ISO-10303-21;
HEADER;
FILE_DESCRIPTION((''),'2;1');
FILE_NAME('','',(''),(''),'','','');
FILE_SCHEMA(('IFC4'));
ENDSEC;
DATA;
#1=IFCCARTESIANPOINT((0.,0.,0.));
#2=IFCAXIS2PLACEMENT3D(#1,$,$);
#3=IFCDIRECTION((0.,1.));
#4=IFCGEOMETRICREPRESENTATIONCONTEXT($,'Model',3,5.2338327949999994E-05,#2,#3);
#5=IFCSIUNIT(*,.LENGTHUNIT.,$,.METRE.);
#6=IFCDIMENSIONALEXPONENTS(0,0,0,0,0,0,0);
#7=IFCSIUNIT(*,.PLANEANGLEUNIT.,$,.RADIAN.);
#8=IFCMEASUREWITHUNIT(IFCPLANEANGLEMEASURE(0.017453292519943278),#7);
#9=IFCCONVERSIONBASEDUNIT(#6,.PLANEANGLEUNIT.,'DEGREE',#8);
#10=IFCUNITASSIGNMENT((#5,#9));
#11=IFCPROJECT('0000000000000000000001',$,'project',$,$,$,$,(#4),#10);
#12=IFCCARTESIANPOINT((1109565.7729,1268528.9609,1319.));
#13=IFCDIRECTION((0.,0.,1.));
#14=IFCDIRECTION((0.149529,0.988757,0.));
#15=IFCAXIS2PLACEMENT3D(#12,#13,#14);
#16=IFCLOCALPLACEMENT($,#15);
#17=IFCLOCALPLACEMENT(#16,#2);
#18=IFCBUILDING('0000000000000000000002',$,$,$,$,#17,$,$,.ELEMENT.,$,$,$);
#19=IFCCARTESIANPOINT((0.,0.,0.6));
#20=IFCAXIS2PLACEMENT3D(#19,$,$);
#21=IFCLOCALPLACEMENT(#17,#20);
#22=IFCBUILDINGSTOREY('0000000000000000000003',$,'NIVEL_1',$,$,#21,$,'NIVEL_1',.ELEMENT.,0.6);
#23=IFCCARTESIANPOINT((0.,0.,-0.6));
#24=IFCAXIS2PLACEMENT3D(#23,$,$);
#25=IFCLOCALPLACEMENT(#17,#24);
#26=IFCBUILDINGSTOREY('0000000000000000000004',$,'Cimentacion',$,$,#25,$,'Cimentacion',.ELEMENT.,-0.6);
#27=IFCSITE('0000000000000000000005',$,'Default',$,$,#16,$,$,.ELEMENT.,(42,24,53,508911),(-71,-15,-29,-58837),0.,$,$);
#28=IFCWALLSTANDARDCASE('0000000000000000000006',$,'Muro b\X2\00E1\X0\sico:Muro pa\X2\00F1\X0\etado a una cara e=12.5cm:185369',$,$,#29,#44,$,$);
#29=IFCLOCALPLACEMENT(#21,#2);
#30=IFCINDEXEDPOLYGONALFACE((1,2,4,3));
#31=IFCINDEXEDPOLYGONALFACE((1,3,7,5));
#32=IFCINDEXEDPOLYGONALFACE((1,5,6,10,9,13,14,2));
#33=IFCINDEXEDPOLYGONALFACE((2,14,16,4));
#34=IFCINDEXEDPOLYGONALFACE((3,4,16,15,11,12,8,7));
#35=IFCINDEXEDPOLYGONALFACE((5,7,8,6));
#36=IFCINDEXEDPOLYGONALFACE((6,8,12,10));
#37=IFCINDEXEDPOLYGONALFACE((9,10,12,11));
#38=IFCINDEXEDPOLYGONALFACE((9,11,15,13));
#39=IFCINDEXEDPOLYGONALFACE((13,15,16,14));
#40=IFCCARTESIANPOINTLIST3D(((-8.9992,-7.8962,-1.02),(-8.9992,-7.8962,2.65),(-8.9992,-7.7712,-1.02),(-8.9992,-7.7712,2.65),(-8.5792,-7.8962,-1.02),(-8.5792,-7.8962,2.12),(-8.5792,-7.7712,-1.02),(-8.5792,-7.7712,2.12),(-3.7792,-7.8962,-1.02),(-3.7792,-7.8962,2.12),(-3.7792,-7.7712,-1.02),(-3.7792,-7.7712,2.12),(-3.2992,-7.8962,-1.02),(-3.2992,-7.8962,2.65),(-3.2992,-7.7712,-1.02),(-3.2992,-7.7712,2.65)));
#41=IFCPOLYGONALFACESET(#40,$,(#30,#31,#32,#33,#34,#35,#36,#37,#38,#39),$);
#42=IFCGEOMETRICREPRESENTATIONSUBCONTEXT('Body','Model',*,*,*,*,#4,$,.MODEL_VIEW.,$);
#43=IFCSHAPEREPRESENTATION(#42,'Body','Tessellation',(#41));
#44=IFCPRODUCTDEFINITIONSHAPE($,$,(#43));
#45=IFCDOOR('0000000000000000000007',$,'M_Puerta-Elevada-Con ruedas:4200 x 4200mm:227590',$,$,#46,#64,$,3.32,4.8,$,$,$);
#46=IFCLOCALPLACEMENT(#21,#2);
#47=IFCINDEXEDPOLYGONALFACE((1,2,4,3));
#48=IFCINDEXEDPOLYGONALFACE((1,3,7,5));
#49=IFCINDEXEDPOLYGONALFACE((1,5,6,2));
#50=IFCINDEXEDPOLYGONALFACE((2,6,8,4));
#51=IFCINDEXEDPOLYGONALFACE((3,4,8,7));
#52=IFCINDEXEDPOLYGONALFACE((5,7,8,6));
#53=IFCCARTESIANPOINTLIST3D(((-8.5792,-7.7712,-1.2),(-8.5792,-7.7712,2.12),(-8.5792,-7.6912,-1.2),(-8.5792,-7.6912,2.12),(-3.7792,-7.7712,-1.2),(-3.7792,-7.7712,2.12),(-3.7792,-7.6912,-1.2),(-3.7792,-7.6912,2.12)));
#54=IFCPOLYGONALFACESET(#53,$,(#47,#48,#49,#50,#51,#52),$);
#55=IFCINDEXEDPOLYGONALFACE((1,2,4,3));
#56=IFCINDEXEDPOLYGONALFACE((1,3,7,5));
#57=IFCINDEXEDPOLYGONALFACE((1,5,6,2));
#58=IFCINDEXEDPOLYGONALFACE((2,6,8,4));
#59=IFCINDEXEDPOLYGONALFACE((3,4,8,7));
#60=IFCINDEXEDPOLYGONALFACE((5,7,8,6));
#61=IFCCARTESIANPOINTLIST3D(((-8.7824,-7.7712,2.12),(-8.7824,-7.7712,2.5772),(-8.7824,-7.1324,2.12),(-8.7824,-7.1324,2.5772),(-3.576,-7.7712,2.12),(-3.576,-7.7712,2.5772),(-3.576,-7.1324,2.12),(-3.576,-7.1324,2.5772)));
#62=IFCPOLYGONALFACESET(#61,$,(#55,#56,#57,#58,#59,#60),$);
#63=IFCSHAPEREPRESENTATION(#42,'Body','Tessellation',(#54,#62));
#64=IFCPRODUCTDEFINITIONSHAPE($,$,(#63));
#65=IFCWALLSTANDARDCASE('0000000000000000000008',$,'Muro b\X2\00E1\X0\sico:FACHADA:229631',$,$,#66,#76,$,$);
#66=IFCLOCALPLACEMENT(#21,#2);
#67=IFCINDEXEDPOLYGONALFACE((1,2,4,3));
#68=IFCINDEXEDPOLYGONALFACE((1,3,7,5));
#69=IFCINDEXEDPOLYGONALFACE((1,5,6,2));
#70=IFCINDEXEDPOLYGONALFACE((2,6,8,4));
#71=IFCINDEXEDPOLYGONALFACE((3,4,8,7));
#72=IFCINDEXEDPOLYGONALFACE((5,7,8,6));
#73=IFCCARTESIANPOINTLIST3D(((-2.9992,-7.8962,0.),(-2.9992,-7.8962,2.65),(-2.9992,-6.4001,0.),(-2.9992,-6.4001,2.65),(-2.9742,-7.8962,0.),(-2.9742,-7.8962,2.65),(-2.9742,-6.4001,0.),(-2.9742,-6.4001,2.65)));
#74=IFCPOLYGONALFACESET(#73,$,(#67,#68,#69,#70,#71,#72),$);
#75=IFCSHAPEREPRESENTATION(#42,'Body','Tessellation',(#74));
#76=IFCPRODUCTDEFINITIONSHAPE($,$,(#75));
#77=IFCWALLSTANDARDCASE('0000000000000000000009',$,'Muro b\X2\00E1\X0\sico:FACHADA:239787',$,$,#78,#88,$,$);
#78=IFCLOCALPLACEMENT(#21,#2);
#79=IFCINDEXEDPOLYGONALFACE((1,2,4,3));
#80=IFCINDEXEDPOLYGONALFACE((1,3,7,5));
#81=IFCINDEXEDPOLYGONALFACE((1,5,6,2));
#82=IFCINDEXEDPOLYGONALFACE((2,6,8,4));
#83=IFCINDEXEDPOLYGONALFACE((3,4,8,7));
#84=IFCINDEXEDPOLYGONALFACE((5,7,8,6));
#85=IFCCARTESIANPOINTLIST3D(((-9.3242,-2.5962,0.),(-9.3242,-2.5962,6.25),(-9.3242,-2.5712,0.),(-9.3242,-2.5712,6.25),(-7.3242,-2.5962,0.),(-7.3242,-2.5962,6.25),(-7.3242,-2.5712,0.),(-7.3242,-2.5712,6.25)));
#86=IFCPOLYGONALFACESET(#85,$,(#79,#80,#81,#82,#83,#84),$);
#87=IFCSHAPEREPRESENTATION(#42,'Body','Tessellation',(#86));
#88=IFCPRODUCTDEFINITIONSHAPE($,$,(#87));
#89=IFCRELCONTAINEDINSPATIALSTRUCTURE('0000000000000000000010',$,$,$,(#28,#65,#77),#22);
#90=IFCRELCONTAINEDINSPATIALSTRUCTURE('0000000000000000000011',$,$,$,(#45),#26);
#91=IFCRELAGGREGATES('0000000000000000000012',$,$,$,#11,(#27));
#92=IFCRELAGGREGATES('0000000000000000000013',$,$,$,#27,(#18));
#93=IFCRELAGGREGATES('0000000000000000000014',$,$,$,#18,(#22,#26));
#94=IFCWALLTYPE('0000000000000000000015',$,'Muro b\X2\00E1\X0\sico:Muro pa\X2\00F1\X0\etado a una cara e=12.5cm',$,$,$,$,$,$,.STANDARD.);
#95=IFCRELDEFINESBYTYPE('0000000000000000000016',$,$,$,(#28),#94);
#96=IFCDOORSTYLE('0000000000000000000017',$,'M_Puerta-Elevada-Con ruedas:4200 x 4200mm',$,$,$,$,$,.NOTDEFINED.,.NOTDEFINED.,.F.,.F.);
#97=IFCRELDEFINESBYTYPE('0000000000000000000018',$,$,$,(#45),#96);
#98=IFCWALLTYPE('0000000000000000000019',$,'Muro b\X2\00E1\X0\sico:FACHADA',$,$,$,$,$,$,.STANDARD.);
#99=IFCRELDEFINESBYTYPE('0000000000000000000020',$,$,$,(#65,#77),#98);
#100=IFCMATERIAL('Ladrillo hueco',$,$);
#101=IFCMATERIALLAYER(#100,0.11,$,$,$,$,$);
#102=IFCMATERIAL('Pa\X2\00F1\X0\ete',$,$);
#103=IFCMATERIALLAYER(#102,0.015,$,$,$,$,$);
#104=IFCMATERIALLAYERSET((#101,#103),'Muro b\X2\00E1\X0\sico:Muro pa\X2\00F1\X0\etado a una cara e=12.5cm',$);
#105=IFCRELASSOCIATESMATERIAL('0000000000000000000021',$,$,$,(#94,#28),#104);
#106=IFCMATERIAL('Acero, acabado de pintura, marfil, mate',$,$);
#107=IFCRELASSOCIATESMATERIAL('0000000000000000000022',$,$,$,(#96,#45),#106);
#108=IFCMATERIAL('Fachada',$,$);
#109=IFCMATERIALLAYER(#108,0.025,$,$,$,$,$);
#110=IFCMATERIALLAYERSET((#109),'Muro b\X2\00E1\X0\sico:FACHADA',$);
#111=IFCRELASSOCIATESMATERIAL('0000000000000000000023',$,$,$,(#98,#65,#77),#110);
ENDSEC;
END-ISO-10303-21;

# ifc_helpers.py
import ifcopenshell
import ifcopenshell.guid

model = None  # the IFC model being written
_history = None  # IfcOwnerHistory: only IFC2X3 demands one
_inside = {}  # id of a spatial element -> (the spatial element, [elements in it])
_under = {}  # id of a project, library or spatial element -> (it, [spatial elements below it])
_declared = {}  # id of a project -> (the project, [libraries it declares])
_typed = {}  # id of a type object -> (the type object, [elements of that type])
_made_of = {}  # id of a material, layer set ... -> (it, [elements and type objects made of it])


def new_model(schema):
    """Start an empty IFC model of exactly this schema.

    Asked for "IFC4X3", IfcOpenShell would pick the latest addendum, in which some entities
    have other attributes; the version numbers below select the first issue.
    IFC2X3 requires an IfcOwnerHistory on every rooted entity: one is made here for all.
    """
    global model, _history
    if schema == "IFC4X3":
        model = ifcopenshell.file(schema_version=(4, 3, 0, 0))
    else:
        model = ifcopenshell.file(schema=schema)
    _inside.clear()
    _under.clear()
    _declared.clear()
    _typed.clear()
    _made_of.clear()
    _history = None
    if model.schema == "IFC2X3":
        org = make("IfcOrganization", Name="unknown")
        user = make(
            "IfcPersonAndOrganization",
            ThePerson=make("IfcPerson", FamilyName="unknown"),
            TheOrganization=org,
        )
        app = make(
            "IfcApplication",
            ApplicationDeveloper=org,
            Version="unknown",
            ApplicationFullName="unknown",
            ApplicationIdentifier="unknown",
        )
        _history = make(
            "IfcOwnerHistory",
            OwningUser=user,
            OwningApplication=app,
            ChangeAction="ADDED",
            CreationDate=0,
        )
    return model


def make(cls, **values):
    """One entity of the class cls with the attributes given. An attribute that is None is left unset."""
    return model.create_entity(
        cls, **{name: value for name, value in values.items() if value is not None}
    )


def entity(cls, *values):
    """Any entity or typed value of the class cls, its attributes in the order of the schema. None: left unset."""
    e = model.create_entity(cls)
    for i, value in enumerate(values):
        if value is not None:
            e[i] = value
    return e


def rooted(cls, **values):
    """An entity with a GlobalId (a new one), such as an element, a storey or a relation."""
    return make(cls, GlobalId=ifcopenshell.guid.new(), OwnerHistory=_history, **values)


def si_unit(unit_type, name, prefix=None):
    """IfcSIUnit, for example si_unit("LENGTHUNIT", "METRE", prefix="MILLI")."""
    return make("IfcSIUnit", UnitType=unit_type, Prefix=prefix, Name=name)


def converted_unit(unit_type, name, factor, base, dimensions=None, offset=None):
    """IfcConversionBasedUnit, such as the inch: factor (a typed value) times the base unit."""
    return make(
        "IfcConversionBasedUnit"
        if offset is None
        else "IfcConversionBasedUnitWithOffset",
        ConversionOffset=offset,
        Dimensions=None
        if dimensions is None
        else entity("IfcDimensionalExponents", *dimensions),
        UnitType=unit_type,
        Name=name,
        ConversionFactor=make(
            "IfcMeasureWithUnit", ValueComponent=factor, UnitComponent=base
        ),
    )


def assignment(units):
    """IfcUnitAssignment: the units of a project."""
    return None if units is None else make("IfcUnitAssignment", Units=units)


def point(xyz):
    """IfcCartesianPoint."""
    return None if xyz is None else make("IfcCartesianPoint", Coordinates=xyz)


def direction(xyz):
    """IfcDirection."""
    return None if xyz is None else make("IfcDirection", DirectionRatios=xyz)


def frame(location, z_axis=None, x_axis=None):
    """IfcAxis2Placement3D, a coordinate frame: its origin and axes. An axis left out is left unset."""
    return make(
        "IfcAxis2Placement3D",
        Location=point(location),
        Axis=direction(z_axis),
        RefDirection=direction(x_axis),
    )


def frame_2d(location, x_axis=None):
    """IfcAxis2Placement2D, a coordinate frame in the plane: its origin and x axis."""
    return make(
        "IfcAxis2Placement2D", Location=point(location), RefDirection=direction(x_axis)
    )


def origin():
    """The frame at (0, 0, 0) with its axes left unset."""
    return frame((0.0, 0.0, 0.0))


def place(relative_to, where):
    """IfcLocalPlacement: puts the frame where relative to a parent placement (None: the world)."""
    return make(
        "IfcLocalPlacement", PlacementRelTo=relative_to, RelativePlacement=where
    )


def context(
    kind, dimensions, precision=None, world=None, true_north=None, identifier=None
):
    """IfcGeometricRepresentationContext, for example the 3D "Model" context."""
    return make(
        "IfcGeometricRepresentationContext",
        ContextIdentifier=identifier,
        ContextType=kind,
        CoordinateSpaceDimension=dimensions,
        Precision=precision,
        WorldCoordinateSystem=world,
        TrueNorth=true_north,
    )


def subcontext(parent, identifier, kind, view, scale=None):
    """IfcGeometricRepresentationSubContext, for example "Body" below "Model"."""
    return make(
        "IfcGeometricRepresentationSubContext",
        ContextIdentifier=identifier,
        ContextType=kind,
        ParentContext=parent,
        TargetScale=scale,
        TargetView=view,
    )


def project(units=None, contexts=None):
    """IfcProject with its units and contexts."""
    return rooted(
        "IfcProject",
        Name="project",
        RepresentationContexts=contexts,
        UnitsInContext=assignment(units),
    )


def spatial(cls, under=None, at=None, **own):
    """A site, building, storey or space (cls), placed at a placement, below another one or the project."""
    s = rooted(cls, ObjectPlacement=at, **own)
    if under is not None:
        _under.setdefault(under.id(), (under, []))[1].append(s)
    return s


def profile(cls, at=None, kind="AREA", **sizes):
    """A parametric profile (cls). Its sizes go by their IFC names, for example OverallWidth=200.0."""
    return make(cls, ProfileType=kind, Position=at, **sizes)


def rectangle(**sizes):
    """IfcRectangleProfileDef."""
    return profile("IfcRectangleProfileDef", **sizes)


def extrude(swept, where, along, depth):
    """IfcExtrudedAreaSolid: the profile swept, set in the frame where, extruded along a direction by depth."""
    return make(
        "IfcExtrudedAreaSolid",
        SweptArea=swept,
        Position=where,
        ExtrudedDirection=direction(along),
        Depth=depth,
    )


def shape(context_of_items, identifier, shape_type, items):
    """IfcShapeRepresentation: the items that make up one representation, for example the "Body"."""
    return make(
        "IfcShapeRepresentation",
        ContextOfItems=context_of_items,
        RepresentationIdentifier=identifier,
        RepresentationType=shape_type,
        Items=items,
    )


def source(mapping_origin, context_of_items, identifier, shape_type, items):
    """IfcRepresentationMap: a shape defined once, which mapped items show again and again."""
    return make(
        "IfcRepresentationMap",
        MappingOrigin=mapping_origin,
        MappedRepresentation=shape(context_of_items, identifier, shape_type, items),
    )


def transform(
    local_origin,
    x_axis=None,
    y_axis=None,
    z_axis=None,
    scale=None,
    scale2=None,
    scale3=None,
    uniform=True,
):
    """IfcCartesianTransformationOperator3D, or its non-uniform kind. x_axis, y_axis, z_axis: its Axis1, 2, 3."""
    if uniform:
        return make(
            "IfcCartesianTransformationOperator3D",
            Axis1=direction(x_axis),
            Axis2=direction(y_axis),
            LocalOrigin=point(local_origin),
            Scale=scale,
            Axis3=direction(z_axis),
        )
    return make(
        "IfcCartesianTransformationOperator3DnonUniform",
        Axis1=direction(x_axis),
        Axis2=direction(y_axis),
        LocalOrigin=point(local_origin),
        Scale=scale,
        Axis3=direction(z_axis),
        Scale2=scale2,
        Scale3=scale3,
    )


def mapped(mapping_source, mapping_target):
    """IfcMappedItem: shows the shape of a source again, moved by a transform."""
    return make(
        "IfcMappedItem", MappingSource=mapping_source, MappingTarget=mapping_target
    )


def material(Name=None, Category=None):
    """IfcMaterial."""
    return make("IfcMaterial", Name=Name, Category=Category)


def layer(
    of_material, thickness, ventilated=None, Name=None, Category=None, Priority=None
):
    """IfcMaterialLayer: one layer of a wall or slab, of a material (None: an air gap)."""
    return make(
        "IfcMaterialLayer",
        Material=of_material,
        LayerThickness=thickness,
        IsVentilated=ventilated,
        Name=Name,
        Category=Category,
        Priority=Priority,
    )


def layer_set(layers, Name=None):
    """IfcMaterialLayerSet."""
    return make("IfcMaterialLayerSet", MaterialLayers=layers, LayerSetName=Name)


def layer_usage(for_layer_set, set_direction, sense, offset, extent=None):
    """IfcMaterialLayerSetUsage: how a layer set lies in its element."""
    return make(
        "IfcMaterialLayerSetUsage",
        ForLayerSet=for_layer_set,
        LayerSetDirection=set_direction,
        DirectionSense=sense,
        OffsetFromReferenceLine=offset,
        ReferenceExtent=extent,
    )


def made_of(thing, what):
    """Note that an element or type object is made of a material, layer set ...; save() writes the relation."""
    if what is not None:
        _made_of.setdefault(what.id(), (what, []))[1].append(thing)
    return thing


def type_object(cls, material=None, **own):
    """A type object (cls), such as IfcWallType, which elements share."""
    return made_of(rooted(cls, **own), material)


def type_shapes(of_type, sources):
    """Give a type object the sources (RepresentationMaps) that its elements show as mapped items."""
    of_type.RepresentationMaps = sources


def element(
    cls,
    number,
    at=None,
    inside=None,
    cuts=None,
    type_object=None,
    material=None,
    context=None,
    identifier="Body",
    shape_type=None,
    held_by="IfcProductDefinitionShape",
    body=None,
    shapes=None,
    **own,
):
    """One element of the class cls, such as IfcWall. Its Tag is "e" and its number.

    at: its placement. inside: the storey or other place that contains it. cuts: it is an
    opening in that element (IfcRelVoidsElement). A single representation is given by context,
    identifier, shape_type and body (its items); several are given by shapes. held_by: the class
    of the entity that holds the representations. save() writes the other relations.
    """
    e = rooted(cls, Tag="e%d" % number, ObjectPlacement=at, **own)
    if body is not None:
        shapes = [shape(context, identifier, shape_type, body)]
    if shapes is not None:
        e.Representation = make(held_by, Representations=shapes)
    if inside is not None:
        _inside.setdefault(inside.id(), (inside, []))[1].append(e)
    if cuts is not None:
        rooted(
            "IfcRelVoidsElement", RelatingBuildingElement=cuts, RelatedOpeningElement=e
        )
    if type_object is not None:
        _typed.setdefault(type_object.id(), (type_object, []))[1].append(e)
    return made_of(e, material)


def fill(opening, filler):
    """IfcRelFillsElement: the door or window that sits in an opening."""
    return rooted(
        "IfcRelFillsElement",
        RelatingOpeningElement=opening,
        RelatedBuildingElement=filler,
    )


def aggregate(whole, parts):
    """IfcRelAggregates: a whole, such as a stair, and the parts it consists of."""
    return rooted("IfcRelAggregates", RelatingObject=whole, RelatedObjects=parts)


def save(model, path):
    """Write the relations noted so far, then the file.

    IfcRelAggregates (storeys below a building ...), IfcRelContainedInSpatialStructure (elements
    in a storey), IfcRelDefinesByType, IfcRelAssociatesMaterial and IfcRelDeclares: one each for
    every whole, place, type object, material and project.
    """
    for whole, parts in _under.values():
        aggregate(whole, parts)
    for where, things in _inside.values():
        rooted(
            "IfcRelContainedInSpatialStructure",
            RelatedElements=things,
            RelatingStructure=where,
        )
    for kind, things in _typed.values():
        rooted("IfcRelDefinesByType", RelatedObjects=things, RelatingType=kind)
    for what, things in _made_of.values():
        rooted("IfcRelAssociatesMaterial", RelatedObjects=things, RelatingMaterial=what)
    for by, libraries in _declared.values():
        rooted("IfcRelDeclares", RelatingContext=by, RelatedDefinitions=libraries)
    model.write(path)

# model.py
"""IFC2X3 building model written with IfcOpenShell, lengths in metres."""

from ifc_helpers import new_model, entity, si_unit, converted_unit, direction, frame, frame_2d, origin, place, context, subcontext, project, spatial, rectangle, extrude, source, transform, mapped, material, layer, layer_set, layer_usage, type_object, type_shapes, element, fill, save


model = new_model("IFC2X3")

# Units and contexts
model_context = context("Model", 3, precision=5.2338327949999994e-05, world=origin(), true_north=direction((0.0, 1.0)))
body_context = subcontext(model_context, "Body", "Model", "MODEL_VIEW")
ifc_project = project(units=[si_unit("LENGTHUNIT", "METRE"), converted_unit("PLANEANGLEUNIT", "DEGREE", entity("IfcPlaneAngleMeasure", 0.017453292519943278), si_unit("PLANEANGLEUNIT", "RADIAN"), dimensions=[0, 0, 0, 0, 0, 0, 0])], contexts=[model_context])

# Site, building, storey
site_placement = place(None, frame((1109565.7729, 1268528.9609, 1319.0), z_axis=(0.0, 0.0, 1.0), x_axis=(0.149529, 0.988757, 0.0)))
site = spatial("IfcSite", under=ifc_project, at=site_placement, Name="Default", CompositionType="ELEMENT", RefLatitude=(42, 24, 53, 508911), RefLongitude=(-71, -15, -29, -58837), RefElevation=0.0)
building_placement = place(site_placement, origin())
building = spatial("IfcBuilding", under=site, at=building_placement, CompositionType="ELEMENT")
storey_1_placement = place(building_placement, frame((0.0, 0.0, 0.6)))
storey_1 = spatial("IfcBuildingStorey", under=building, at=storey_1_placement, Name="NIVEL_1", LongName="NIVEL_1", CompositionType="ELEMENT", Elevation=0.6)

# Shared definitions
ifc_material_1 = material(Name="Pañete")
ifc_material_2 = material(Name="Ladrillo hueco")
ifc_layer_1 = layer(ifc_material_2, 0.11)
ifc_layer_2 = layer(ifc_material_1, 0.015)
ifc_layer_set_1 = layer_set([ifc_layer_1, ifc_layer_2], Name="Muro básico:Muro pañetado a una cara e=12.5cm")
wall_type_1 = type_object("IfcWallType", Name="Muro básico:Muro pañetado a una cara e=12.5cm", PredefinedType="STANDARD", material=ifc_layer_set_1)

# Wall, opening
ifc_layer_usage_1 = layer_usage(ifc_layer_set_1, "AXIS2", "POSITIVE", -0.0625)
wall_1_placement = place(storey_1_placement, frame((-8.9992, -7.8337, -1.02)))
wall_1 = element("IfcWallStandardCase", 1, at=wall_1_placement, inside=storey_1, type_object=wall_type_1, material=ifc_layer_usage_1, Name="Muro básico:Muro pañetado a una cara e=12.5cm:185369", context=body_context, shape_type="SweptSolid", body=[
    extrude(rectangle(XDim=5.7, YDim=0.125, at=frame_2d((2.85, 0.0), x_axis=(1.0, 0.0))), origin(), (0.0, 0.0, 1.0), 3.67),
])
opening_1_placement = place(wall_1_placement, frame((0.42, -0.0625, -0.18)))
opening_1 = element("IfcOpeningElement", 2, at=opening_1_placement, cuts=wall_1, ObjectType="Opening", context=body_context, shape_type="SweptSolid", body=[
    extrude(rectangle(XDim=3.32, YDim=4.8, at=frame_2d((1.66, 2.4), x_axis=(1.0, 0.0))), frame((0.0, 0.0, 0.0), z_axis=(0.0, 1.0, 0.0), x_axis=(0.0, 0.0, 1.0)), (0.0, 0.0, 1.0), 0.125),
])

# Shared definitions
storey_2_placement = place(building_placement, frame((0.0, 0.0, -0.6)))
storey_2 = spatial("IfcBuildingStorey", under=building, at=storey_2_placement, Name="Cimentacion", LongName="Cimentacion", CompositionType="ELEMENT", Elevation=-0.6)

# Door
ifc_material_3 = material(Name="Acero, acabado de pintura, marfil, mate")
door_style = type_object("IfcDoorStyle", Name="M_Puerta-Elevada-Con ruedas:4200 x 4200mm", ConstructionType="NOTDEFINED", OperationType="NOTDEFINED", ParameterTakesPrecedence=False, Sizeable=False, material=ifc_material_3)
shared_shape_1 = source(origin(), body_context, "Body", "SweptSolid", [
    extrude(rectangle(XDim=4.8, YDim=0.08, at=frame_2d((0.0, 0.0), x_axis=(1.0, 0.0))), frame((2.4, -0.04, 0.0), z_axis=(0.0, 0.0, 1.0), x_axis=(-1.0, 0.0, 0.0)), (0.0, 0.0, 1.0), 3.32),
    extrude(rectangle(XDim=0.6388, YDim=5.2064, at=frame_2d((0.0, 0.0), x_axis=(1.0, 0.0))), frame((2.4, -0.3194, 3.32), z_axis=(0.0, 0.0, 1.0), x_axis=(0.0, 1.0, 0.0)), (0.0, 0.0, 1.0), 0.4572),
])
type_shapes(door_style, [shared_shape_1])
door_placement = place(opening_1_placement, frame((4.8, 0.125, 0.0), z_axis=(0.0, 0.0, 1.0), x_axis=(-1.0, 0.0, 0.0)))
door = element("IfcDoor", 3, at=door_placement, inside=storey_2, type_object=door_style, material=ifc_material_3, Name="M_Puerta-Elevada-Con ruedas:4200 x 4200mm:227590", OverallHeight=3.32, OverallWidth=4.8, context=body_context, shape_type="MappedRepresentation", body=[
    mapped(shared_shape_1, transform((0.0, 0.0, 0.0), scale=1.0)),
])
fill(opening_1, door)

# Shared definitions
ifc_material_4 = material(Name="Fachada")
ifc_layer_3 = layer(ifc_material_4, 0.025)
ifc_layer_set_2 = layer_set([ifc_layer_3], Name="Muro básico:FACHADA")
wall_type_2 = type_object("IfcWallType", Name="Muro básico:FACHADA", PredefinedType="STANDARD", material=ifc_layer_set_2)

# Walls
ifc_layer_usage_2 = layer_usage(ifc_layer_set_2, "AXIS2", "POSITIVE", -0.0125)
wall_2_placement = place(storey_1_placement, frame((-2.9867, -7.8962, 0.0), z_axis=(0.0, 0.0, 1.0), x_axis=(0.0, 1.0, 0.0)))
element("IfcWallStandardCase", 4, at=wall_2_placement, inside=storey_1, type_object=wall_type_2, material=ifc_layer_usage_2, Name="Muro básico:FACHADA:229631", context=body_context, shape_type="SweptSolid", body=[
    extrude(rectangle(XDim=1.4961, YDim=0.025, at=frame_2d((0.748, 0.0), x_axis=(-1.0, 0.0))), origin(), (0.0, 0.0, 1.0), 2.65),
])
ifc_layer_usage_3 = layer_usage(ifc_layer_set_2, "AXIS2", "POSITIVE", -0.0125)
wall_3_placement = place(storey_1_placement, frame((-7.3242, -2.5837, 0.0), z_axis=(0.0, 0.0, 1.0), x_axis=(-1.0, 0.0, 0.0)))
element("IfcWallStandardCase", 5, at=wall_3_placement, inside=storey_1, type_object=wall_type_2, material=ifc_layer_usage_3, Name="Muro básico:FACHADA:239787", context=body_context, shape_type="SweptSolid", body=[
    extrude(rectangle(XDim=2.0, YDim=0.025, at=frame_2d((1.0, 0.0), x_axis=(-1.0, 0.0))), origin(), (0.0, 0.0, 1.0), 6.25),
])

save(model, "model.ifc")
